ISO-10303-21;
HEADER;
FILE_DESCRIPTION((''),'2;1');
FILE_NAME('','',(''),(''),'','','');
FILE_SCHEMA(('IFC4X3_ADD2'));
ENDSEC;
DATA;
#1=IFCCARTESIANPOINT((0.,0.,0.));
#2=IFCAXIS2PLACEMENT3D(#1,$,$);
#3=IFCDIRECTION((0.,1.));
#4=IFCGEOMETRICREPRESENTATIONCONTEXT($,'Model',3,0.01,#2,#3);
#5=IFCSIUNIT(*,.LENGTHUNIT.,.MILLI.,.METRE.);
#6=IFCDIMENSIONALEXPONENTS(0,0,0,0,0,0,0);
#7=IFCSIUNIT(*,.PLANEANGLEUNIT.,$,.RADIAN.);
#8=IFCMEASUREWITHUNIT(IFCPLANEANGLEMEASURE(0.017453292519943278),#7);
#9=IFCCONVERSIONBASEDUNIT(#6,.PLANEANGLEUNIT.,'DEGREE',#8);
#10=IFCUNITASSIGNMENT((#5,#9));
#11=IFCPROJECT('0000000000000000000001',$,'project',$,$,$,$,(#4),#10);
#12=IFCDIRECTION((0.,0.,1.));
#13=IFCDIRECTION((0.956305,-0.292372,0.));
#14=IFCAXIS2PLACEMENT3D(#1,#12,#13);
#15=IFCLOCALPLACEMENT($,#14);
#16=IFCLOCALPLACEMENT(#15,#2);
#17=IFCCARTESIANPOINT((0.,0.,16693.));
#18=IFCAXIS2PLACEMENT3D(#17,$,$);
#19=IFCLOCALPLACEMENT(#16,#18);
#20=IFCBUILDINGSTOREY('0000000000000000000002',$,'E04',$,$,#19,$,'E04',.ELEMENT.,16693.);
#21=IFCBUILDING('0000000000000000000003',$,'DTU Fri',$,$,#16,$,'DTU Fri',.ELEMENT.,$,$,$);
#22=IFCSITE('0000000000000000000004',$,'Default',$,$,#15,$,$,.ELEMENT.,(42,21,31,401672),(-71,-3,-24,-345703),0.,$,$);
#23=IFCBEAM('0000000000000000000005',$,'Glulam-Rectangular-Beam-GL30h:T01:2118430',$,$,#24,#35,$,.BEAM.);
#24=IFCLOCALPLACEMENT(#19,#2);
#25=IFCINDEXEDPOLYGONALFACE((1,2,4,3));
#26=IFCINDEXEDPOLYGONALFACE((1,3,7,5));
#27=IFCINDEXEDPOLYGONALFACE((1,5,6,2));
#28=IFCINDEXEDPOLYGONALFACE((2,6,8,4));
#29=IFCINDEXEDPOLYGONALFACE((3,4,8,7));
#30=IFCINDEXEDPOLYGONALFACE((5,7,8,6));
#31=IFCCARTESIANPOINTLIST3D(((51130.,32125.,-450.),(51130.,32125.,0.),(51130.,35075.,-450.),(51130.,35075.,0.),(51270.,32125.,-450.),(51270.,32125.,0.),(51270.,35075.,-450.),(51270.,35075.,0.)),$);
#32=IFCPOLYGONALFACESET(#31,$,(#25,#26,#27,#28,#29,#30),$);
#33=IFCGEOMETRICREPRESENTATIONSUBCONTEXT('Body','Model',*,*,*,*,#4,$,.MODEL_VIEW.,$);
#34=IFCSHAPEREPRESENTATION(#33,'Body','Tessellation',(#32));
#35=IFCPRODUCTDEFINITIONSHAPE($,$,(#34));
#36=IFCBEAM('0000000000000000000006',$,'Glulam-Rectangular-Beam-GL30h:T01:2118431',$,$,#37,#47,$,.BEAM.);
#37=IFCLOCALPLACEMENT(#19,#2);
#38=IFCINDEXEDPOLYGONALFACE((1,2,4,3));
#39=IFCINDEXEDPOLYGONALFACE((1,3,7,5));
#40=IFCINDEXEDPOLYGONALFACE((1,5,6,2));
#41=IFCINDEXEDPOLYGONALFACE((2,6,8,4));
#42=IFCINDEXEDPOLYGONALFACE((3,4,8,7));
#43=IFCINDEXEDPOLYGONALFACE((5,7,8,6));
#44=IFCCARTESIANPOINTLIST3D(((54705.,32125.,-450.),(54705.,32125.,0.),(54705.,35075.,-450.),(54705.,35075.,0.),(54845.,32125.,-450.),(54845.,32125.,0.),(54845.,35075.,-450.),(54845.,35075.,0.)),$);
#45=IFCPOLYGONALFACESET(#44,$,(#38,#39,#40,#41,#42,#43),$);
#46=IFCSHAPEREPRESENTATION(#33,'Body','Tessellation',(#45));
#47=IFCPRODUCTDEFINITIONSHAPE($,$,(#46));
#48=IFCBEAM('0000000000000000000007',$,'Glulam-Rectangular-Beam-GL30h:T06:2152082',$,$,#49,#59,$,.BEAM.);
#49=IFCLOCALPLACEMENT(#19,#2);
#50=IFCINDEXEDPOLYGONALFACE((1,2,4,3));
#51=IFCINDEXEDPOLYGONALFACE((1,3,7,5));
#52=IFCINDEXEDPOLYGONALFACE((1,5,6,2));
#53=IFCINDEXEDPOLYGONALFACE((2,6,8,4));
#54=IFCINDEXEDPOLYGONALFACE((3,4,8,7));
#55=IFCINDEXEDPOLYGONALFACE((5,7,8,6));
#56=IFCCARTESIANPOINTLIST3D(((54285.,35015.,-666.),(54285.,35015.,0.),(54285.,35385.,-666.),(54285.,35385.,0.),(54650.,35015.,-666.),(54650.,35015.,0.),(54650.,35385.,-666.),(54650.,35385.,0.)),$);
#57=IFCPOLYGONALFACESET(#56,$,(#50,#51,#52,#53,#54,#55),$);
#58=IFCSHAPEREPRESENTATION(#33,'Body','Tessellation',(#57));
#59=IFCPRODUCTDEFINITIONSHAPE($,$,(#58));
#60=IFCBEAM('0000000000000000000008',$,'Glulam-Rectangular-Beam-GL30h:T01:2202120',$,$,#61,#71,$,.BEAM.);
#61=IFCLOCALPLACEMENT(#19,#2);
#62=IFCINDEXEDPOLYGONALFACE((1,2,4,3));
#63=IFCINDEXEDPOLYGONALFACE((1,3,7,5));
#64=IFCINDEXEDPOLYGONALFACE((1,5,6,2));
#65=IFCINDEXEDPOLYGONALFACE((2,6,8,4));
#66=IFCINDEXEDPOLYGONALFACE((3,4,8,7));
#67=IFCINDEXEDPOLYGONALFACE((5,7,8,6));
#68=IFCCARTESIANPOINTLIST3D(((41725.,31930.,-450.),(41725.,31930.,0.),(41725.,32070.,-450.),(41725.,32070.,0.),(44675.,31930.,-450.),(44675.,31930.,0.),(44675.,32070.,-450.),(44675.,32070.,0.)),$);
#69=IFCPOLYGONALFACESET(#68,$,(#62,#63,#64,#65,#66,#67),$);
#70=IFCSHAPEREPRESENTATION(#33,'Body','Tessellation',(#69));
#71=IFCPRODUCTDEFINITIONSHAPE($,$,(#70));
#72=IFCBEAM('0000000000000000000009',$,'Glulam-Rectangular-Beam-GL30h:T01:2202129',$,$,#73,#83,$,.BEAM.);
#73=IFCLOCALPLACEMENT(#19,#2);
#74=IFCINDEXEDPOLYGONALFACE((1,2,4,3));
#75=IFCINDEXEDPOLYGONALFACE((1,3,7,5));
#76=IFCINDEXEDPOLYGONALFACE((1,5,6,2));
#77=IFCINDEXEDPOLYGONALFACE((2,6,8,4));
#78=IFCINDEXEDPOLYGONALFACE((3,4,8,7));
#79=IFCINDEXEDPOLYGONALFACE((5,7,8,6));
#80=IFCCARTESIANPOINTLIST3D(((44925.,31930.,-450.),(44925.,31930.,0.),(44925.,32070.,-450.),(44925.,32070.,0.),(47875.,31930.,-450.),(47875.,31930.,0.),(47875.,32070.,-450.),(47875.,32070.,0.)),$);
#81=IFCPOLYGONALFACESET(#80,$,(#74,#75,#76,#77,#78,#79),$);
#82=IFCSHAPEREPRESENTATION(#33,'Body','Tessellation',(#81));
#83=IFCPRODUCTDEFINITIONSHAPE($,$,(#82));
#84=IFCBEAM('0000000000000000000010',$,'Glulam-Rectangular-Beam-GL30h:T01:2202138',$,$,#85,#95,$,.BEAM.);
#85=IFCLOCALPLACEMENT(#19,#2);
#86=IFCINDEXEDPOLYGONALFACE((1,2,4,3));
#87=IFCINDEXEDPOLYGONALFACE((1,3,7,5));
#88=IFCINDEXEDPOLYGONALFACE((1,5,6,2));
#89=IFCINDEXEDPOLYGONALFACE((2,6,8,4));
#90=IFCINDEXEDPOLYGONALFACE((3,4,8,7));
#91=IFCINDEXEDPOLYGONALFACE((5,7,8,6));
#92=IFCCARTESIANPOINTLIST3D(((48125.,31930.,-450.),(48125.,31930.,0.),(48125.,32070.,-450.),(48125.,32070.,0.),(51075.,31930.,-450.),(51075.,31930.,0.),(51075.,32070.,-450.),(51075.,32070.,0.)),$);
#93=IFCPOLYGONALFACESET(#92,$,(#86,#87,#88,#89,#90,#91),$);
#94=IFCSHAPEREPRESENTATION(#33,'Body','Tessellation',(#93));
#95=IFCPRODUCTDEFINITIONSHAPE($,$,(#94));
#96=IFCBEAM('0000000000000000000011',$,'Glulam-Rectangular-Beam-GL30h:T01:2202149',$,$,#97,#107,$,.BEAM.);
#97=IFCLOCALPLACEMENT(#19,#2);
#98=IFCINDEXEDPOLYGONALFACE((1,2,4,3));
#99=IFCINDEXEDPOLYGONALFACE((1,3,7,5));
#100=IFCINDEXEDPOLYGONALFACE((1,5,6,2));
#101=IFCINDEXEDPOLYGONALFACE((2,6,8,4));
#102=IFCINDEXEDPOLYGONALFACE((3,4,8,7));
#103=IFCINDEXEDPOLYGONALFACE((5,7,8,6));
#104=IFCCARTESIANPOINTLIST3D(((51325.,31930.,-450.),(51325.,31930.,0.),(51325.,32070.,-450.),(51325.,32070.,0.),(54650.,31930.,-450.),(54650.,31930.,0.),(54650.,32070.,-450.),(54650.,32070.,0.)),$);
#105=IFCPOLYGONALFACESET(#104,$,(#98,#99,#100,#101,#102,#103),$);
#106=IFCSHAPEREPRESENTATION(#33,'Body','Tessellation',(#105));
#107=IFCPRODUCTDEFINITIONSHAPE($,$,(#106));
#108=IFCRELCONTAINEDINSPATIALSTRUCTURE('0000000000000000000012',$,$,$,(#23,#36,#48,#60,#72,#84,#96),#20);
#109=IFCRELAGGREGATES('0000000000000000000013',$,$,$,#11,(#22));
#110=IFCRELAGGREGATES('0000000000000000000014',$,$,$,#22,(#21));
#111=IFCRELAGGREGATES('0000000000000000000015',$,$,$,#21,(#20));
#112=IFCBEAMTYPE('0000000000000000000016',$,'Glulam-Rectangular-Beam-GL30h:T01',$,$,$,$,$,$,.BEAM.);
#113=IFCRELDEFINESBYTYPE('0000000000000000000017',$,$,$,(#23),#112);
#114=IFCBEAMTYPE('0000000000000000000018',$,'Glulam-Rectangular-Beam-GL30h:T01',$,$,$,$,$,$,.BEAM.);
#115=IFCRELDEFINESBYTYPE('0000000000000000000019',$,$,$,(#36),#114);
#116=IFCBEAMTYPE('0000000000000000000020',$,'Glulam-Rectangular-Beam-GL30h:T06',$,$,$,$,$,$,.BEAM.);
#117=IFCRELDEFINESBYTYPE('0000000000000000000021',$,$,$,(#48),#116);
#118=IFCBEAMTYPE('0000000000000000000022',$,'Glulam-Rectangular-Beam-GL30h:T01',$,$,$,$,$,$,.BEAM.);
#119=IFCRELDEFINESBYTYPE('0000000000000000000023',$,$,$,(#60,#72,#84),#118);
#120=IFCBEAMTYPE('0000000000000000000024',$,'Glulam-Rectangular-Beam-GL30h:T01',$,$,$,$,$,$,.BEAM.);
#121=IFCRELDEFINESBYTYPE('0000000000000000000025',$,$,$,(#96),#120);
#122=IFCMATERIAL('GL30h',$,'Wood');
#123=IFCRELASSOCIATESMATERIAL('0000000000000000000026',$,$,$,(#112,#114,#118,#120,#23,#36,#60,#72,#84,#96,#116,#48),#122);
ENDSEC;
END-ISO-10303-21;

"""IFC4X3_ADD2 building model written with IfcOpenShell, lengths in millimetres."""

from ifc_helpers import new_model, entity, si_unit, converted_unit, direction, frame, origin, origin_2d_with_axis, place, context, subcontext, project, spatial, rectangle, extrude, source, transform, mapped, material, material_profile, profile_set, profile_usage, type_object, type_shapes, element, save


model = new_model("IFC4X3_ADD2")

# Units and contexts
model_context = context("Model", 3, precision=0.01, world=origin(), true_north=direction((0.0, 1.0)))
body_context = subcontext(model_context, "Body", "Model", "MODEL_VIEW")
ifc_project = project(units=[si_unit("LENGTHUNIT", "METRE", prefix="MILLI"), converted_unit("PLANEANGLEUNIT", "DEGREE", entity("IfcPlaneAngleMeasure", 0.017453292519943278), si_unit("PLANEANGLEUNIT", "RADIAN"), dimensions=[0, 0, 0, 0, 0, 0, 0])], contexts=[model_context])

# Site, building, storey
site_placement = place(None, frame((0.0, 0.0, 0.0), z_axis=(0.0, 0.0, 1.0), x_axis=(0.956305, -0.292372, 0.0)))
site = spatial("IfcSite", under=ifc_project, at=site_placement, Name="Default", CompositionType="ELEMENT", RefLatitude=(42, 21, 31, 401672), RefLongitude=(-71, -3, -24, -345703), RefElevation=0.0)
building_placement = place(site_placement, origin())
building = spatial("IfcBuilding", under=site, at=building_placement, Name="DTU Fri", LongName="DTU Fri", CompositionType="ELEMENT")
storey_placement = place(building_placement, frame((0.0, 0.0, 16693.0)))
storey = spatial("IfcBuildingStorey", under=building, at=storey_placement, Name="E04", LongName="E04", CompositionType="ELEMENT", Elevation=16693.0)

# Beams
ifc_material = material(Name="GL30h", Category="Wood")
ifc_material_profile_1 = material_profile(ifc_material, rectangle(XDim=666.0, YDim=370.0, at=origin_2d_with_axis()), Name="T06")
ifc_profile_set_1 = profile_set([ifc_material_profile_1], Name="T06")
ifc_profile_usage_1 = profile_usage(ifc_profile_set_1, cardinal=8)
ifc_material_profile_2 = material_profile(ifc_material, rectangle(XDim=450.0, YDim=140.0, at=origin_2d_with_axis()), Name="T01")
ifc_profile_set_2 = profile_set([ifc_material_profile_2], Name="T01")
ifc_profile_usage_2 = profile_usage(ifc_profile_set_2, cardinal=8)
beam_type_1 = type_object("IfcBeamType", Name="Glulam-Rectangular-Beam-GL30h:T01", PredefinedType="BEAM", material=ifc_profile_set_2)
shared_shape_1 = source(origin(), body_context, "Body", "SweptSolid", [
    extrude(rectangle(XDim=450.0, YDim=140.0, at=origin_2d_with_axis()), frame((-1475.0, 0.0, 0.0), z_axis=(1.0, 0.0, 0.0), x_axis=(0.0, 0.0, -1.0)), (0.0, 0.0, 1.0), 2950.0),
])
type_shapes(beam_type_1, [shared_shape_1])
for number, where, z_axis, x_axis, name in (
    (1, (51200.0, 33600.0, -225.0), (0.0, 0.0, 1.0), (0.0, 1.0, 0.0), "Glulam-Rectangular-Beam-GL30h:T01:2118430"),
):
    element("IfcBeam", number, at=place(storey_placement, frame(where, z_axis=z_axis, x_axis=x_axis)), inside=storey, type_object=beam_type_1, material=ifc_profile_usage_2, Name=name, PredefinedType="BEAM", context=body_context, shape_type="MappedRepresentation", body=[
        mapped(shared_shape_1, transform((0.0, 0.0, 0.0), scale=1.0)),
    ])
beam_type_2 = type_object("IfcBeamType", Name="Glulam-Rectangular-Beam-GL30h:T01", PredefinedType="BEAM", material=ifc_profile_set_2)
shared_shape_2 = source(origin(), body_context, "Body", "SweptSolid", [
    extrude(rectangle(XDim=450.0, YDim=140.0, at=origin_2d_with_axis()), frame((-1400.0, 0.0, 0.0), z_axis=(1.0, 0.0, 0.0), x_axis=(0.0, 0.0, -1.0)), (0.0, 0.0, 1.0), 2950.0),
])
type_shapes(beam_type_2, [shared_shape_2])
beam_1_placement = place(storey_placement, frame((54775.0, 33525.0, -225.0), z_axis=(0.0, 0.0, 1.0), x_axis=(0.0, 1.0, 0.0)))
element("IfcBeam", 2, at=beam_1_placement, inside=storey, type_object=beam_type_2, material=ifc_profile_usage_2, Name="Glulam-Rectangular-Beam-GL30h:T01:2118431", PredefinedType="BEAM", context=body_context, shape_type="MappedRepresentation", body=[
    mapped(shared_shape_2, transform((0.0, 0.0, 0.0), scale=1.0)),
])
beam_type_3 = type_object("IfcBeamType", Name="Glulam-Rectangular-Beam-GL30h:T06", PredefinedType="BEAM", material=ifc_profile_set_1)
shared_shape_3 = source(origin(), body_context, "Body", "SweptSolid", [
    extrude(rectangle(XDim=666.0, YDim=370.0, at=origin_2d_with_axis()), frame((-112.5, 0.0, 0.0), z_axis=(1.0, 0.0, 0.0), x_axis=(0.0, 0.0, -1.0)), (0.0, 0.0, 1.0), 365.0),
])
type_shapes(beam_type_3, [shared_shape_3])
beam_2_placement = place(storey_placement, frame((54397.5, 35200.0, -333.0)))
element("IfcBeam", 3, at=beam_2_placement, inside=storey, type_object=beam_type_3, material=ifc_profile_usage_1, Name="Glulam-Rectangular-Beam-GL30h:T06:2152082", PredefinedType="BEAM", context=body_context, shape_type="MappedRepresentation", body=[
    mapped(shared_shape_3, transform((0.0, 0.0, 0.0), scale=1.0)),
])
beam_type_4 = type_object("IfcBeamType", Name="Glulam-Rectangular-Beam-GL30h:T01", PredefinedType="BEAM", material=ifc_profile_set_2)
shared_shape_4 = source(origin(), body_context, "Body", "SweptSolid", [
    extrude(rectangle(XDim=450.0, YDim=140.0, at=origin_2d_with_axis()), frame((-1475.0, 0.0, 0.0), z_axis=(1.0, 0.0, 0.0), x_axis=(0.0, 0.0, -1.0)), (0.0, 0.0, 1.0), 2950.0),
])
type_shapes(beam_type_4, [shared_shape_4])
for number, where, z_axis, x_axis, name in (
    (4, (43200.0, 32000.0, -225.0), (0.0, 0.0, 1.0), (-1.0, 0.0, 0.0), "Glulam-Rectangular-Beam-GL30h:T01:2202120"),
    (5, (46400.0, 32000.0, -225.0), (0.0, 0.0, 1.0), (-1.0, 0.0, 0.0), "Glulam-Rectangular-Beam-GL30h:T01:2202129"),
    (6, (49600.0, 32000.0, -225.0), (0.0, 0.0, 1.0), (-1.0, 0.0, 0.0), "Glulam-Rectangular-Beam-GL30h:T01:2202138"),
):
    element("IfcBeam", number, at=place(storey_placement, frame(where, z_axis=z_axis, x_axis=x_axis)), inside=storey, type_object=beam_type_4, material=ifc_profile_usage_2, Name=name, PredefinedType="BEAM", context=body_context, shape_type="MappedRepresentation", body=[
        mapped(shared_shape_4, transform((0.0, 0.0, 0.0), scale=1.0)),
    ])
beam_type_5 = type_object("IfcBeamType", Name="Glulam-Rectangular-Beam-GL30h:T01", PredefinedType="BEAM", material=ifc_profile_set_2)
shared_shape_5 = source(origin(), body_context, "Body", "SweptSolid", [
    extrude(rectangle(XDim=450.0, YDim=140.0, at=origin_2d_with_axis()), frame((-1650.0, 0.0, 0.0), z_axis=(1.0, 0.0, 0.0), x_axis=(0.0, 0.0, -1.0)), (0.0, 0.0, 1.0), 3325.0),
])
type_shapes(beam_type_5, [shared_shape_5])
beam_3_placement = place(storey_placement, frame((53000.0, 32000.0, -225.0), z_axis=(0.0, 0.0, 1.0), x_axis=(-1.0, 0.0, 0.0)))
element("IfcBeam", 7, at=beam_3_placement, inside=storey, type_object=beam_type_5, material=ifc_profile_usage_2, Name="Glulam-Rectangular-Beam-GL30h:T01:2202149", PredefinedType="BEAM", context=body_context, shape_type="MappedRepresentation", body=[
    mapped(shared_shape_5, transform((0.0, 0.0, 0.0), scale=1.0)),
])

save(model, "model.ifc")
